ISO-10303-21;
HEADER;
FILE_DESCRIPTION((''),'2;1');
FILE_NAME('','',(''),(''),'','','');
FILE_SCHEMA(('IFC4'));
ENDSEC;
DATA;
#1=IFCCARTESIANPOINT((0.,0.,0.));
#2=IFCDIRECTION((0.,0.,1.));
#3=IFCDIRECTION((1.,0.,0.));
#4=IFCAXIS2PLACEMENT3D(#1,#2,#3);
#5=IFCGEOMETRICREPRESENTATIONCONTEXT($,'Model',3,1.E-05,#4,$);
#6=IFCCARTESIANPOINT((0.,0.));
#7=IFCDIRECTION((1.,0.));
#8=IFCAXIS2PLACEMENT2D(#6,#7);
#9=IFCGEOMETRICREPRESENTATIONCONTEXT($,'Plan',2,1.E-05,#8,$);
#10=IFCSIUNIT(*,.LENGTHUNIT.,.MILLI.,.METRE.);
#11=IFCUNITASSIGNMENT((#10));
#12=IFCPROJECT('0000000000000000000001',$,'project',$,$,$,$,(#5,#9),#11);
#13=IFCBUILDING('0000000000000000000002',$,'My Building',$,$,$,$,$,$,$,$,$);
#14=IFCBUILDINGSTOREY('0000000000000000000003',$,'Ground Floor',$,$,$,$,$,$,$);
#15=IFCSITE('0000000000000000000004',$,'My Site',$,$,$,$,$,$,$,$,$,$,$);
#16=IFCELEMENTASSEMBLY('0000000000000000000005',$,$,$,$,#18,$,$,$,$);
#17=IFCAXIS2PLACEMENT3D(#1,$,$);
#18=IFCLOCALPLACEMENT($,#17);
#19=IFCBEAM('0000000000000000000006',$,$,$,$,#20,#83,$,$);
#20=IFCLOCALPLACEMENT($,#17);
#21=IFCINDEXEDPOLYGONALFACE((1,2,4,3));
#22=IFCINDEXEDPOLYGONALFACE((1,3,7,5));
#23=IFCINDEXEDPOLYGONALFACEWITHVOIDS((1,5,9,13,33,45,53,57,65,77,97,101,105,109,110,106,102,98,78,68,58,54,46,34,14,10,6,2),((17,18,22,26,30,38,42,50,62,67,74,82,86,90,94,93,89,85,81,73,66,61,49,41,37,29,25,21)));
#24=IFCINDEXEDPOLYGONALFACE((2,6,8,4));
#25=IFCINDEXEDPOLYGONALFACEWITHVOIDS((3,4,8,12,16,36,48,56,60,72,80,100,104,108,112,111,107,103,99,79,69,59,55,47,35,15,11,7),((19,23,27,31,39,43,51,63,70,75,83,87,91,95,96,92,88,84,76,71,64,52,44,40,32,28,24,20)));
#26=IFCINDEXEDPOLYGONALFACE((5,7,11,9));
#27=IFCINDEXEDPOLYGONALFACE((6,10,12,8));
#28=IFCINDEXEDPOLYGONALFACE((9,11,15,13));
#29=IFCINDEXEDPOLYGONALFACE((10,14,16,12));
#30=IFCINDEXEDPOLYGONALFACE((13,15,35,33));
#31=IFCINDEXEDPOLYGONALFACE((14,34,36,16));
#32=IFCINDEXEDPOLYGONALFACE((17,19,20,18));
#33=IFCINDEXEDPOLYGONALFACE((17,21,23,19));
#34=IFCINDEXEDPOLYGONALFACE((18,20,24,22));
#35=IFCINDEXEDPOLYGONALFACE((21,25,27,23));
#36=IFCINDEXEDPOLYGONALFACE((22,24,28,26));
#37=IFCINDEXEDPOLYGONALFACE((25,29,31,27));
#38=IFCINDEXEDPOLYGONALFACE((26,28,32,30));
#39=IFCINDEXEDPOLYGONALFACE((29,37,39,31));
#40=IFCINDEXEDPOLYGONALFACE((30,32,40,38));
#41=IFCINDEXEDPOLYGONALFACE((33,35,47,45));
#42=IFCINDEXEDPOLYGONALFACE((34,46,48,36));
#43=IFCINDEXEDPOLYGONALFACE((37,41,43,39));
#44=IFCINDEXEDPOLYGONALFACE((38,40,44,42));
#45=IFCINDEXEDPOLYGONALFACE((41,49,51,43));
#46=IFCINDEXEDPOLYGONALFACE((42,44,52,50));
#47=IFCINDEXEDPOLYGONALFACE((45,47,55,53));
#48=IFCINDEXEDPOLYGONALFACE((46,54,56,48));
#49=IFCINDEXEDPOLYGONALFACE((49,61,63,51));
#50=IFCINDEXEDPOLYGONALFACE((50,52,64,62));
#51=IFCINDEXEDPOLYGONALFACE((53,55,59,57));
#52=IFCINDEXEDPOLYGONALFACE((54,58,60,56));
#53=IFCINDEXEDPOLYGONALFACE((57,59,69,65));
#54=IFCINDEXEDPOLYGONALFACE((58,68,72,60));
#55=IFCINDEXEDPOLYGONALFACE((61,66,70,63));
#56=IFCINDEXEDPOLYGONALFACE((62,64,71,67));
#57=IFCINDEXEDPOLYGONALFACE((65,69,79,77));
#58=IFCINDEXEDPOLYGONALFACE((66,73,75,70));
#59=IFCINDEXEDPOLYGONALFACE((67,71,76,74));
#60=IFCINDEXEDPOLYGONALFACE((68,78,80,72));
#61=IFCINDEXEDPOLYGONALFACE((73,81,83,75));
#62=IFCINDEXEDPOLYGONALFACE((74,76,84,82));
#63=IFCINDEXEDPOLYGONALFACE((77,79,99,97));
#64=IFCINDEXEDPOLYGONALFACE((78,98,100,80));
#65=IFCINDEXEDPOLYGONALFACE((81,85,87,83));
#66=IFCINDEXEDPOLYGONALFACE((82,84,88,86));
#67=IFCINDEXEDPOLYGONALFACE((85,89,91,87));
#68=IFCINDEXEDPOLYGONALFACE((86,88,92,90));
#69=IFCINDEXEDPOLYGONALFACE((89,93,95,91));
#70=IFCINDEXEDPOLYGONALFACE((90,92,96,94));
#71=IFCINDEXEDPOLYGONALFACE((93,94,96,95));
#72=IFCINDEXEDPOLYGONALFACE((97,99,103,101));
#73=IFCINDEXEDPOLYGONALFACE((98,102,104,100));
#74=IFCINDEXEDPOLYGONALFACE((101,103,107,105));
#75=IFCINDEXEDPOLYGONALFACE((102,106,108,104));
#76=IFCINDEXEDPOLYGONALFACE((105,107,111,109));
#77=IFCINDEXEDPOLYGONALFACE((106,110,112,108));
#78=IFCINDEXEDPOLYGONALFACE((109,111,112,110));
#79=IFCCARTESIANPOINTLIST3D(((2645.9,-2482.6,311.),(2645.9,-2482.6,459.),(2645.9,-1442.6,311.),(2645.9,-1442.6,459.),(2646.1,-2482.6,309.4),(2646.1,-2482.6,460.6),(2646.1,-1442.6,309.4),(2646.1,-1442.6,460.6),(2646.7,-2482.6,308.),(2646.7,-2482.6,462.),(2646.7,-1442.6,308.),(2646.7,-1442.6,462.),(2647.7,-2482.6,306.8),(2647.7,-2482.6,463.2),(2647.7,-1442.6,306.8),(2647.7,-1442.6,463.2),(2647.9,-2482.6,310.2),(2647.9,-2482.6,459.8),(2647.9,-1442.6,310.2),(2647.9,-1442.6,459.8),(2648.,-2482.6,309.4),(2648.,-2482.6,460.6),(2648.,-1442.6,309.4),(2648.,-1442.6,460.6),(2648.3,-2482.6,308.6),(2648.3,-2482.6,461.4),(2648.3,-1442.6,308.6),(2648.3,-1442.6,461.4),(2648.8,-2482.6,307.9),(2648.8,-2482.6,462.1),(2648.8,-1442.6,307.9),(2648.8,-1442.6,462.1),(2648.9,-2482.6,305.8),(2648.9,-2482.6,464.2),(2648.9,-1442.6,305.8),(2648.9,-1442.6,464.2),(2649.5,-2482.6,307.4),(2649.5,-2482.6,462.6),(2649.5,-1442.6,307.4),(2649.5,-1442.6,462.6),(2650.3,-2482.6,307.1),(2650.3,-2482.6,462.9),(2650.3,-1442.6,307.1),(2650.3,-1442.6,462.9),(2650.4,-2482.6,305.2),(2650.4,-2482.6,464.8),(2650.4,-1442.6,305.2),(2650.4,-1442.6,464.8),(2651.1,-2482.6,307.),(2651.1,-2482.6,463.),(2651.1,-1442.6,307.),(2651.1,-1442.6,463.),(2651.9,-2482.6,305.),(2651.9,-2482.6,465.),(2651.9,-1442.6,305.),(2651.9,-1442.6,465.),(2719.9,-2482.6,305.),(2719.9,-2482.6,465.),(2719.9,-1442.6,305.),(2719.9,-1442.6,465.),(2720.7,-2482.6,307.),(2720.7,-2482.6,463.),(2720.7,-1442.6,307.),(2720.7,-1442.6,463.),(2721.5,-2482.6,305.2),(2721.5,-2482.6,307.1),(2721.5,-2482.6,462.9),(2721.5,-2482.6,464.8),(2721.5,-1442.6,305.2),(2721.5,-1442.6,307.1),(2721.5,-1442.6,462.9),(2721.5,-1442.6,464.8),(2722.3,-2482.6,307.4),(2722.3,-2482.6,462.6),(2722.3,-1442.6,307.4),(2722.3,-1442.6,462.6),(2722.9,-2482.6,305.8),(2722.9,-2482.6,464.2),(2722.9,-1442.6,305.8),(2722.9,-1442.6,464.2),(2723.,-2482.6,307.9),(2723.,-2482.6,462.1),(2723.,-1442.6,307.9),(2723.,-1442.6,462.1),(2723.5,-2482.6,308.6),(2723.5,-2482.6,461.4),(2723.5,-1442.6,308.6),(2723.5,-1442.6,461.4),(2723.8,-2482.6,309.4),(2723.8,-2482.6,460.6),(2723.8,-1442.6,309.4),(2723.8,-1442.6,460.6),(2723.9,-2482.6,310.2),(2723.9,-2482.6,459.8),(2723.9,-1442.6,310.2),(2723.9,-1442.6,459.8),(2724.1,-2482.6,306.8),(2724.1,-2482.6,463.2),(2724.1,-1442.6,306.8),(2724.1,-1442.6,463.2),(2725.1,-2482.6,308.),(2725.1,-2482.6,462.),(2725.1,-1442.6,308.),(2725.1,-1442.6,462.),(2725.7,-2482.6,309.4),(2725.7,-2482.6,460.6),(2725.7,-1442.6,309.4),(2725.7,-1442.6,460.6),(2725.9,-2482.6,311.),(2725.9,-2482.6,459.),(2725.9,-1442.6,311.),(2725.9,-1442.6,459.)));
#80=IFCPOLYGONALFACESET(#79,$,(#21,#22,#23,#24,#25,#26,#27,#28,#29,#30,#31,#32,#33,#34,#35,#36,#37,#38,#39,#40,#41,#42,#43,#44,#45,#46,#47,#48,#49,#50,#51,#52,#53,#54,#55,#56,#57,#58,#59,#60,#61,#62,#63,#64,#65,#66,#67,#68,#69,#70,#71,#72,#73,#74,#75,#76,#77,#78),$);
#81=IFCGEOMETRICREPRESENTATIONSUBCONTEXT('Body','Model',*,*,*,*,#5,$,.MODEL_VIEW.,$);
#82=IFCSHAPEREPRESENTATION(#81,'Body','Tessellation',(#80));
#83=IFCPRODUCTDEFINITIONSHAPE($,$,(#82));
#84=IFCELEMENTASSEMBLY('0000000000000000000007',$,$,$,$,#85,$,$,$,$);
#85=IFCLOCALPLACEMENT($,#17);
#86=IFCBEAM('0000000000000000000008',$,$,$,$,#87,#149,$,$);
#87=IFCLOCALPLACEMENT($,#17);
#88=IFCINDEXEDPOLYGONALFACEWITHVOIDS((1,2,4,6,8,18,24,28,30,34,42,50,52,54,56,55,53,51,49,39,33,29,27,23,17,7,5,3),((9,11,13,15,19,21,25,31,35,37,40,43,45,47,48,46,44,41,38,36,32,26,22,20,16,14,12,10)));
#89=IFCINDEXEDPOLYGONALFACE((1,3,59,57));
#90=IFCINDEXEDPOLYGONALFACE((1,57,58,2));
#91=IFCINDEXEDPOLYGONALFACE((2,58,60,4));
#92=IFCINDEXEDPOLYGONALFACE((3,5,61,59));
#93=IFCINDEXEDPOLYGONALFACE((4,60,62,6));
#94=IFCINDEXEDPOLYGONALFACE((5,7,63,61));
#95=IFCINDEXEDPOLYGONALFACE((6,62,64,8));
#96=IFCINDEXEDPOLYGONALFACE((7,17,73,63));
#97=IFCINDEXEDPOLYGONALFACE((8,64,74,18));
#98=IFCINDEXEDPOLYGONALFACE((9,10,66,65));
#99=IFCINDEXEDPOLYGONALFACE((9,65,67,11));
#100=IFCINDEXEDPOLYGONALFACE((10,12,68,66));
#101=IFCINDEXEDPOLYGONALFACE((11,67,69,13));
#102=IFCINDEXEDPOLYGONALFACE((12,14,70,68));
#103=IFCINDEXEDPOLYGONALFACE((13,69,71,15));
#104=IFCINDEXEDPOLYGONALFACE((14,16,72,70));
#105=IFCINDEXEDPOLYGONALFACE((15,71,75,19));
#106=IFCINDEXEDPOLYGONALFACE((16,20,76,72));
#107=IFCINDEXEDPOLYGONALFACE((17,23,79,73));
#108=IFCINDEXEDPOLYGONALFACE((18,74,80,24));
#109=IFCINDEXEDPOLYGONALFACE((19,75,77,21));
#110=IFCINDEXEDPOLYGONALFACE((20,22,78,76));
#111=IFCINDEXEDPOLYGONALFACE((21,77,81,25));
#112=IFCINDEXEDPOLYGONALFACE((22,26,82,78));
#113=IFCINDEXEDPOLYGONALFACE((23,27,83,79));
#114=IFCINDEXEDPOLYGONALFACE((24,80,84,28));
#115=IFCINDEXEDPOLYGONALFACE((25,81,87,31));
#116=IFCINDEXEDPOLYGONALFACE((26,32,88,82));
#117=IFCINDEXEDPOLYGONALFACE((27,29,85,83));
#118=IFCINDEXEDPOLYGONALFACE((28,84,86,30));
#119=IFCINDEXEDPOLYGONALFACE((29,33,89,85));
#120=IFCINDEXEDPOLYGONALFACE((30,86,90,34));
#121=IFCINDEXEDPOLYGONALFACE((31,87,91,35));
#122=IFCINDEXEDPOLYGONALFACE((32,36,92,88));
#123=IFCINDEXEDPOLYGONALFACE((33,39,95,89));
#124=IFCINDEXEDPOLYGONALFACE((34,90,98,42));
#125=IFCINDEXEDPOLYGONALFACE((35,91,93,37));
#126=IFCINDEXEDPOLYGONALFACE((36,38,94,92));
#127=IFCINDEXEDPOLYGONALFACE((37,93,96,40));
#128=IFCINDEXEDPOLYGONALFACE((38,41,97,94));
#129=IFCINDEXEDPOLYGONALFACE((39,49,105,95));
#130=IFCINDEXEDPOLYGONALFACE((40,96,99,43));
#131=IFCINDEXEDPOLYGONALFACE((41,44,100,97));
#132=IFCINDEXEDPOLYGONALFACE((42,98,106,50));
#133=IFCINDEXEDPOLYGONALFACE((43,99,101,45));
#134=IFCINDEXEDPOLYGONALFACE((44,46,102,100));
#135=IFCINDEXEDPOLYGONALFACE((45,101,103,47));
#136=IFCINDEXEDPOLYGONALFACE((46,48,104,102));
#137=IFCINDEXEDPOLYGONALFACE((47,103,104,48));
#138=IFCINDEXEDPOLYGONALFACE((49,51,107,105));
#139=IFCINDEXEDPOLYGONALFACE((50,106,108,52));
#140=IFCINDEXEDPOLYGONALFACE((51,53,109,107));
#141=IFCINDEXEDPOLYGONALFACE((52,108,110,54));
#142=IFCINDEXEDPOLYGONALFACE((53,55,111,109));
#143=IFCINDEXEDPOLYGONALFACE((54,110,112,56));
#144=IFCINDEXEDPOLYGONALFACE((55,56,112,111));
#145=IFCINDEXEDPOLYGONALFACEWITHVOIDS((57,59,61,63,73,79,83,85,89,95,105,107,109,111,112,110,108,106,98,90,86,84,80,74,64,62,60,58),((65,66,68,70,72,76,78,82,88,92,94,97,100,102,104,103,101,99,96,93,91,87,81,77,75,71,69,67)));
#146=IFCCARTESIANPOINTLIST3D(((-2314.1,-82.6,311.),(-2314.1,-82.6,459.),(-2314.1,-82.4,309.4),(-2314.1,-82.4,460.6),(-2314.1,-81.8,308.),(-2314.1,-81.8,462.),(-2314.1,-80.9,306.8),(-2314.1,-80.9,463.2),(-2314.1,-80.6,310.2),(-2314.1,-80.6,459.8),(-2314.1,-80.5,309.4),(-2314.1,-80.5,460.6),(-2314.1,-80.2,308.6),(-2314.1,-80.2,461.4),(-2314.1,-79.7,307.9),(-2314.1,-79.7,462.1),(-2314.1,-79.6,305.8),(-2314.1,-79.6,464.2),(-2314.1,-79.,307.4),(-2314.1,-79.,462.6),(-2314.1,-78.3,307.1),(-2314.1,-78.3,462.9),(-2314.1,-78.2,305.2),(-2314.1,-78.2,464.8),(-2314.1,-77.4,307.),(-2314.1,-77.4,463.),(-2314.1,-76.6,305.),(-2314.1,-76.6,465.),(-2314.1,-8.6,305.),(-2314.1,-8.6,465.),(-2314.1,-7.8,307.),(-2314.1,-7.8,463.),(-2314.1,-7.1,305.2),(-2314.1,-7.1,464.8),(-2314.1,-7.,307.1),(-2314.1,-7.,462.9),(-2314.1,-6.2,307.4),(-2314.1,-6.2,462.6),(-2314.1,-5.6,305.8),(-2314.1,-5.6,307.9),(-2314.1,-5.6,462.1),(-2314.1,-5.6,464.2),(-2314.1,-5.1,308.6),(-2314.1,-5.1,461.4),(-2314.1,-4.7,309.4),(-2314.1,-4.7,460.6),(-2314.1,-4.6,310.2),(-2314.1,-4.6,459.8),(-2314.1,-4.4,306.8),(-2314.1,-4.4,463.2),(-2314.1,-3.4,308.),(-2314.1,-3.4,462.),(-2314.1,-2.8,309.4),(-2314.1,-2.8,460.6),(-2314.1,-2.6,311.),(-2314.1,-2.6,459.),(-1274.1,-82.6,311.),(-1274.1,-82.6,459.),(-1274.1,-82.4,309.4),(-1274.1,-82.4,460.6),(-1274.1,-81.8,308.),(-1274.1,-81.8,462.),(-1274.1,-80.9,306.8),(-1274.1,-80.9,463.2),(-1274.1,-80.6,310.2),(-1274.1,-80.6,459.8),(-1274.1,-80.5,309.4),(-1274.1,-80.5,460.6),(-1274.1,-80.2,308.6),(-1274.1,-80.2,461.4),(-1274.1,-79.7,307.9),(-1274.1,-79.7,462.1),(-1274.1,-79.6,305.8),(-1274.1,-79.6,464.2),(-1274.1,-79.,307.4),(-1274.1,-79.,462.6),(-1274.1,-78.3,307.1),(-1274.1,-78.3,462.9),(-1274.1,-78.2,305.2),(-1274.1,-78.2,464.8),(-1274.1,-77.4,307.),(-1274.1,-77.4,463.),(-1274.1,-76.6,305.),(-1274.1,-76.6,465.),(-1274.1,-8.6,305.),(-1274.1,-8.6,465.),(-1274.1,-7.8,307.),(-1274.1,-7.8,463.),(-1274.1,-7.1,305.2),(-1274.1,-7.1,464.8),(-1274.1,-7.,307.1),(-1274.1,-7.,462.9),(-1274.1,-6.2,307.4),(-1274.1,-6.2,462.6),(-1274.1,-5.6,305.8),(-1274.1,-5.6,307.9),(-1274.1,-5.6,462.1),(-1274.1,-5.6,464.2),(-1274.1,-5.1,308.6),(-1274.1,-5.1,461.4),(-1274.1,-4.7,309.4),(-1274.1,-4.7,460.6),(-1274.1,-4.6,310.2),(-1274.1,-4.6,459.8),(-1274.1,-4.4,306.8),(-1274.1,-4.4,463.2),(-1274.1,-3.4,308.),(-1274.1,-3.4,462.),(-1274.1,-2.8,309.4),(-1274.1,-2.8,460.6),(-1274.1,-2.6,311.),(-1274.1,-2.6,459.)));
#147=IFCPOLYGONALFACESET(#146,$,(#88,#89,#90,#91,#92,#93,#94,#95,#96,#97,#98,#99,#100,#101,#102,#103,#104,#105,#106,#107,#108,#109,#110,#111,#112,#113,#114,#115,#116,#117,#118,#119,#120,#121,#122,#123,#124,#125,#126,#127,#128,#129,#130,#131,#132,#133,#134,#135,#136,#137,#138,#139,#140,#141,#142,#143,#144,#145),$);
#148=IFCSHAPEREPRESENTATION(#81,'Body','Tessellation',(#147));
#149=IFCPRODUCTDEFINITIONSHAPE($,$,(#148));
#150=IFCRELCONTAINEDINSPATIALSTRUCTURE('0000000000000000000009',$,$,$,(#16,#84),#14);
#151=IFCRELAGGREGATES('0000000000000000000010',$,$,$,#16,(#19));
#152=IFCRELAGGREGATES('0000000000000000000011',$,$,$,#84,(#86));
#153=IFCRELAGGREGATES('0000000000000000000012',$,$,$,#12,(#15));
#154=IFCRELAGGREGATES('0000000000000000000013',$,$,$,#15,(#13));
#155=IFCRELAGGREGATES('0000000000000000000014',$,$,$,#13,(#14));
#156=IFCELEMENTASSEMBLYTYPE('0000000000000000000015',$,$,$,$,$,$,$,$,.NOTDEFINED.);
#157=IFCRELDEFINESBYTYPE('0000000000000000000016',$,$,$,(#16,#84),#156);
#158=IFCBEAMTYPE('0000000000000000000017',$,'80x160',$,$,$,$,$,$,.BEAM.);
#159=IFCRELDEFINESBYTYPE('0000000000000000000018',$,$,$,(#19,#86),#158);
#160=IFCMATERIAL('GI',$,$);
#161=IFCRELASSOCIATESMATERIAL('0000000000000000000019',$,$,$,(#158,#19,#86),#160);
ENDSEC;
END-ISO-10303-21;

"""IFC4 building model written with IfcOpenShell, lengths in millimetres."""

from ifc_helpers import new_model, si_unit, frame, origin_with_axes, origin_2d_with_axis, place, context, subcontext, project, spatial, hollow_rectangle, extrude, material, material_profile, profile_set, profile_usage, type_object, element, aggregate, save


model = new_model("IFC4")

# Units and contexts
model_context = context("Model", 3, precision=1e-05, world=origin_with_axes())
plan_context = context("Plan", 2, precision=1e-05, world=origin_2d_with_axis())
body_context = subcontext(model_context, "Body", "Model", "MODEL_VIEW")
ifc_project = project(units=[si_unit("LENGTHUNIT", "METRE", prefix="MILLI")], contexts=[model_context, plan_context])

# Site, building, storey
site = spatial("IfcSite", under=ifc_project, Name="My Site")
building = spatial("IfcBuilding", under=site, Name="My Building")
storey = spatial("IfcBuildingStorey", under=building, Name="Ground Floor")

# Shared definitions
ifc_material_1 = material(Name="GI")

# Element assemblies, beams
element_assembly_type_1 = type_object("IfcElementAssemblyType", PredefinedType="NOTDEFINED")
ifc_material_profile_1 = material_profile(ifc_material_1, hollow_rectangle(XDim=80.0, YDim=160.0, WallThickness=2.0, InnerFilletRadius=3.2, OuterFilletRadius=6.0))
ifc_profile_set_1 = profile_set([ifc_material_profile_1], Name="80x160 GI Rectangular Hollow")
beam_type = type_object("IfcBeamType", Name="80x160", PredefinedType="BEAM", material=ifc_profile_set_1)
assembly_1_placement = place(None, frame((2685.9, -2562.6, 385.0), z_axis=(0.0, 1.0, 0.0), x_axis=(1.0, 0.0, 0.0)))
assembly_1 = element("IfcElementAssembly", 1, at=assembly_1_placement, inside=storey, type_object=element_assembly_type_1)
ifc_profile_usage_1 = profile_usage(ifc_profile_set_1)
beam_1_placement = place(assembly_1_placement, frame((0.0, 0.0, 80.0), z_axis=(0.0, 0.0, 1.0), x_axis=(1.0, 0.0, 0.0)))
beam_1 = element("IfcBeam", 2, at=beam_1_placement, type_object=beam_type, material=ifc_profile_usage_1, context=body_context, shape_type="SweptSolid", body=[
    extrude(hollow_rectangle(XDim=80.0, YDim=160.0, WallThickness=2.0, InnerFilletRadius=3.2, OuterFilletRadius=6.0), origin_with_axes(), (0.0, 0.0, 1.0), 1040.0),
])
aggregate(assembly_1, [beam_1])
assembly_2_placement = place(None, frame((-2394.1, -42.6, 385.0), z_axis=(1.0, 0.0, 0.0), x_axis=(0.0, 1.0, 0.0)))
assembly_2 = element("IfcElementAssembly", 3, at=assembly_2_placement, inside=storey, type_object=element_assembly_type_1)
ifc_profile_usage_2 = profile_usage(ifc_profile_set_1)
beam_2_placement = place(assembly_2_placement, frame((0.0, 0.0, 80.0), z_axis=(0.0, 0.0, 1.0), x_axis=(1.0, 0.0, 0.0)))
beam_2 = element("IfcBeam", 4, at=beam_2_placement, type_object=beam_type, material=ifc_profile_usage_2, context=body_context, shape_type="SweptSolid", body=[
    extrude(hollow_rectangle(XDim=80.0, YDim=160.0, WallThickness=2.0, InnerFilletRadius=3.2, OuterFilletRadius=6.0), origin_with_axes(), (0.0, 0.0, 1.0), 1040.0),
])
aggregate(assembly_2, [beam_2])

save(model, "model.ifc")
